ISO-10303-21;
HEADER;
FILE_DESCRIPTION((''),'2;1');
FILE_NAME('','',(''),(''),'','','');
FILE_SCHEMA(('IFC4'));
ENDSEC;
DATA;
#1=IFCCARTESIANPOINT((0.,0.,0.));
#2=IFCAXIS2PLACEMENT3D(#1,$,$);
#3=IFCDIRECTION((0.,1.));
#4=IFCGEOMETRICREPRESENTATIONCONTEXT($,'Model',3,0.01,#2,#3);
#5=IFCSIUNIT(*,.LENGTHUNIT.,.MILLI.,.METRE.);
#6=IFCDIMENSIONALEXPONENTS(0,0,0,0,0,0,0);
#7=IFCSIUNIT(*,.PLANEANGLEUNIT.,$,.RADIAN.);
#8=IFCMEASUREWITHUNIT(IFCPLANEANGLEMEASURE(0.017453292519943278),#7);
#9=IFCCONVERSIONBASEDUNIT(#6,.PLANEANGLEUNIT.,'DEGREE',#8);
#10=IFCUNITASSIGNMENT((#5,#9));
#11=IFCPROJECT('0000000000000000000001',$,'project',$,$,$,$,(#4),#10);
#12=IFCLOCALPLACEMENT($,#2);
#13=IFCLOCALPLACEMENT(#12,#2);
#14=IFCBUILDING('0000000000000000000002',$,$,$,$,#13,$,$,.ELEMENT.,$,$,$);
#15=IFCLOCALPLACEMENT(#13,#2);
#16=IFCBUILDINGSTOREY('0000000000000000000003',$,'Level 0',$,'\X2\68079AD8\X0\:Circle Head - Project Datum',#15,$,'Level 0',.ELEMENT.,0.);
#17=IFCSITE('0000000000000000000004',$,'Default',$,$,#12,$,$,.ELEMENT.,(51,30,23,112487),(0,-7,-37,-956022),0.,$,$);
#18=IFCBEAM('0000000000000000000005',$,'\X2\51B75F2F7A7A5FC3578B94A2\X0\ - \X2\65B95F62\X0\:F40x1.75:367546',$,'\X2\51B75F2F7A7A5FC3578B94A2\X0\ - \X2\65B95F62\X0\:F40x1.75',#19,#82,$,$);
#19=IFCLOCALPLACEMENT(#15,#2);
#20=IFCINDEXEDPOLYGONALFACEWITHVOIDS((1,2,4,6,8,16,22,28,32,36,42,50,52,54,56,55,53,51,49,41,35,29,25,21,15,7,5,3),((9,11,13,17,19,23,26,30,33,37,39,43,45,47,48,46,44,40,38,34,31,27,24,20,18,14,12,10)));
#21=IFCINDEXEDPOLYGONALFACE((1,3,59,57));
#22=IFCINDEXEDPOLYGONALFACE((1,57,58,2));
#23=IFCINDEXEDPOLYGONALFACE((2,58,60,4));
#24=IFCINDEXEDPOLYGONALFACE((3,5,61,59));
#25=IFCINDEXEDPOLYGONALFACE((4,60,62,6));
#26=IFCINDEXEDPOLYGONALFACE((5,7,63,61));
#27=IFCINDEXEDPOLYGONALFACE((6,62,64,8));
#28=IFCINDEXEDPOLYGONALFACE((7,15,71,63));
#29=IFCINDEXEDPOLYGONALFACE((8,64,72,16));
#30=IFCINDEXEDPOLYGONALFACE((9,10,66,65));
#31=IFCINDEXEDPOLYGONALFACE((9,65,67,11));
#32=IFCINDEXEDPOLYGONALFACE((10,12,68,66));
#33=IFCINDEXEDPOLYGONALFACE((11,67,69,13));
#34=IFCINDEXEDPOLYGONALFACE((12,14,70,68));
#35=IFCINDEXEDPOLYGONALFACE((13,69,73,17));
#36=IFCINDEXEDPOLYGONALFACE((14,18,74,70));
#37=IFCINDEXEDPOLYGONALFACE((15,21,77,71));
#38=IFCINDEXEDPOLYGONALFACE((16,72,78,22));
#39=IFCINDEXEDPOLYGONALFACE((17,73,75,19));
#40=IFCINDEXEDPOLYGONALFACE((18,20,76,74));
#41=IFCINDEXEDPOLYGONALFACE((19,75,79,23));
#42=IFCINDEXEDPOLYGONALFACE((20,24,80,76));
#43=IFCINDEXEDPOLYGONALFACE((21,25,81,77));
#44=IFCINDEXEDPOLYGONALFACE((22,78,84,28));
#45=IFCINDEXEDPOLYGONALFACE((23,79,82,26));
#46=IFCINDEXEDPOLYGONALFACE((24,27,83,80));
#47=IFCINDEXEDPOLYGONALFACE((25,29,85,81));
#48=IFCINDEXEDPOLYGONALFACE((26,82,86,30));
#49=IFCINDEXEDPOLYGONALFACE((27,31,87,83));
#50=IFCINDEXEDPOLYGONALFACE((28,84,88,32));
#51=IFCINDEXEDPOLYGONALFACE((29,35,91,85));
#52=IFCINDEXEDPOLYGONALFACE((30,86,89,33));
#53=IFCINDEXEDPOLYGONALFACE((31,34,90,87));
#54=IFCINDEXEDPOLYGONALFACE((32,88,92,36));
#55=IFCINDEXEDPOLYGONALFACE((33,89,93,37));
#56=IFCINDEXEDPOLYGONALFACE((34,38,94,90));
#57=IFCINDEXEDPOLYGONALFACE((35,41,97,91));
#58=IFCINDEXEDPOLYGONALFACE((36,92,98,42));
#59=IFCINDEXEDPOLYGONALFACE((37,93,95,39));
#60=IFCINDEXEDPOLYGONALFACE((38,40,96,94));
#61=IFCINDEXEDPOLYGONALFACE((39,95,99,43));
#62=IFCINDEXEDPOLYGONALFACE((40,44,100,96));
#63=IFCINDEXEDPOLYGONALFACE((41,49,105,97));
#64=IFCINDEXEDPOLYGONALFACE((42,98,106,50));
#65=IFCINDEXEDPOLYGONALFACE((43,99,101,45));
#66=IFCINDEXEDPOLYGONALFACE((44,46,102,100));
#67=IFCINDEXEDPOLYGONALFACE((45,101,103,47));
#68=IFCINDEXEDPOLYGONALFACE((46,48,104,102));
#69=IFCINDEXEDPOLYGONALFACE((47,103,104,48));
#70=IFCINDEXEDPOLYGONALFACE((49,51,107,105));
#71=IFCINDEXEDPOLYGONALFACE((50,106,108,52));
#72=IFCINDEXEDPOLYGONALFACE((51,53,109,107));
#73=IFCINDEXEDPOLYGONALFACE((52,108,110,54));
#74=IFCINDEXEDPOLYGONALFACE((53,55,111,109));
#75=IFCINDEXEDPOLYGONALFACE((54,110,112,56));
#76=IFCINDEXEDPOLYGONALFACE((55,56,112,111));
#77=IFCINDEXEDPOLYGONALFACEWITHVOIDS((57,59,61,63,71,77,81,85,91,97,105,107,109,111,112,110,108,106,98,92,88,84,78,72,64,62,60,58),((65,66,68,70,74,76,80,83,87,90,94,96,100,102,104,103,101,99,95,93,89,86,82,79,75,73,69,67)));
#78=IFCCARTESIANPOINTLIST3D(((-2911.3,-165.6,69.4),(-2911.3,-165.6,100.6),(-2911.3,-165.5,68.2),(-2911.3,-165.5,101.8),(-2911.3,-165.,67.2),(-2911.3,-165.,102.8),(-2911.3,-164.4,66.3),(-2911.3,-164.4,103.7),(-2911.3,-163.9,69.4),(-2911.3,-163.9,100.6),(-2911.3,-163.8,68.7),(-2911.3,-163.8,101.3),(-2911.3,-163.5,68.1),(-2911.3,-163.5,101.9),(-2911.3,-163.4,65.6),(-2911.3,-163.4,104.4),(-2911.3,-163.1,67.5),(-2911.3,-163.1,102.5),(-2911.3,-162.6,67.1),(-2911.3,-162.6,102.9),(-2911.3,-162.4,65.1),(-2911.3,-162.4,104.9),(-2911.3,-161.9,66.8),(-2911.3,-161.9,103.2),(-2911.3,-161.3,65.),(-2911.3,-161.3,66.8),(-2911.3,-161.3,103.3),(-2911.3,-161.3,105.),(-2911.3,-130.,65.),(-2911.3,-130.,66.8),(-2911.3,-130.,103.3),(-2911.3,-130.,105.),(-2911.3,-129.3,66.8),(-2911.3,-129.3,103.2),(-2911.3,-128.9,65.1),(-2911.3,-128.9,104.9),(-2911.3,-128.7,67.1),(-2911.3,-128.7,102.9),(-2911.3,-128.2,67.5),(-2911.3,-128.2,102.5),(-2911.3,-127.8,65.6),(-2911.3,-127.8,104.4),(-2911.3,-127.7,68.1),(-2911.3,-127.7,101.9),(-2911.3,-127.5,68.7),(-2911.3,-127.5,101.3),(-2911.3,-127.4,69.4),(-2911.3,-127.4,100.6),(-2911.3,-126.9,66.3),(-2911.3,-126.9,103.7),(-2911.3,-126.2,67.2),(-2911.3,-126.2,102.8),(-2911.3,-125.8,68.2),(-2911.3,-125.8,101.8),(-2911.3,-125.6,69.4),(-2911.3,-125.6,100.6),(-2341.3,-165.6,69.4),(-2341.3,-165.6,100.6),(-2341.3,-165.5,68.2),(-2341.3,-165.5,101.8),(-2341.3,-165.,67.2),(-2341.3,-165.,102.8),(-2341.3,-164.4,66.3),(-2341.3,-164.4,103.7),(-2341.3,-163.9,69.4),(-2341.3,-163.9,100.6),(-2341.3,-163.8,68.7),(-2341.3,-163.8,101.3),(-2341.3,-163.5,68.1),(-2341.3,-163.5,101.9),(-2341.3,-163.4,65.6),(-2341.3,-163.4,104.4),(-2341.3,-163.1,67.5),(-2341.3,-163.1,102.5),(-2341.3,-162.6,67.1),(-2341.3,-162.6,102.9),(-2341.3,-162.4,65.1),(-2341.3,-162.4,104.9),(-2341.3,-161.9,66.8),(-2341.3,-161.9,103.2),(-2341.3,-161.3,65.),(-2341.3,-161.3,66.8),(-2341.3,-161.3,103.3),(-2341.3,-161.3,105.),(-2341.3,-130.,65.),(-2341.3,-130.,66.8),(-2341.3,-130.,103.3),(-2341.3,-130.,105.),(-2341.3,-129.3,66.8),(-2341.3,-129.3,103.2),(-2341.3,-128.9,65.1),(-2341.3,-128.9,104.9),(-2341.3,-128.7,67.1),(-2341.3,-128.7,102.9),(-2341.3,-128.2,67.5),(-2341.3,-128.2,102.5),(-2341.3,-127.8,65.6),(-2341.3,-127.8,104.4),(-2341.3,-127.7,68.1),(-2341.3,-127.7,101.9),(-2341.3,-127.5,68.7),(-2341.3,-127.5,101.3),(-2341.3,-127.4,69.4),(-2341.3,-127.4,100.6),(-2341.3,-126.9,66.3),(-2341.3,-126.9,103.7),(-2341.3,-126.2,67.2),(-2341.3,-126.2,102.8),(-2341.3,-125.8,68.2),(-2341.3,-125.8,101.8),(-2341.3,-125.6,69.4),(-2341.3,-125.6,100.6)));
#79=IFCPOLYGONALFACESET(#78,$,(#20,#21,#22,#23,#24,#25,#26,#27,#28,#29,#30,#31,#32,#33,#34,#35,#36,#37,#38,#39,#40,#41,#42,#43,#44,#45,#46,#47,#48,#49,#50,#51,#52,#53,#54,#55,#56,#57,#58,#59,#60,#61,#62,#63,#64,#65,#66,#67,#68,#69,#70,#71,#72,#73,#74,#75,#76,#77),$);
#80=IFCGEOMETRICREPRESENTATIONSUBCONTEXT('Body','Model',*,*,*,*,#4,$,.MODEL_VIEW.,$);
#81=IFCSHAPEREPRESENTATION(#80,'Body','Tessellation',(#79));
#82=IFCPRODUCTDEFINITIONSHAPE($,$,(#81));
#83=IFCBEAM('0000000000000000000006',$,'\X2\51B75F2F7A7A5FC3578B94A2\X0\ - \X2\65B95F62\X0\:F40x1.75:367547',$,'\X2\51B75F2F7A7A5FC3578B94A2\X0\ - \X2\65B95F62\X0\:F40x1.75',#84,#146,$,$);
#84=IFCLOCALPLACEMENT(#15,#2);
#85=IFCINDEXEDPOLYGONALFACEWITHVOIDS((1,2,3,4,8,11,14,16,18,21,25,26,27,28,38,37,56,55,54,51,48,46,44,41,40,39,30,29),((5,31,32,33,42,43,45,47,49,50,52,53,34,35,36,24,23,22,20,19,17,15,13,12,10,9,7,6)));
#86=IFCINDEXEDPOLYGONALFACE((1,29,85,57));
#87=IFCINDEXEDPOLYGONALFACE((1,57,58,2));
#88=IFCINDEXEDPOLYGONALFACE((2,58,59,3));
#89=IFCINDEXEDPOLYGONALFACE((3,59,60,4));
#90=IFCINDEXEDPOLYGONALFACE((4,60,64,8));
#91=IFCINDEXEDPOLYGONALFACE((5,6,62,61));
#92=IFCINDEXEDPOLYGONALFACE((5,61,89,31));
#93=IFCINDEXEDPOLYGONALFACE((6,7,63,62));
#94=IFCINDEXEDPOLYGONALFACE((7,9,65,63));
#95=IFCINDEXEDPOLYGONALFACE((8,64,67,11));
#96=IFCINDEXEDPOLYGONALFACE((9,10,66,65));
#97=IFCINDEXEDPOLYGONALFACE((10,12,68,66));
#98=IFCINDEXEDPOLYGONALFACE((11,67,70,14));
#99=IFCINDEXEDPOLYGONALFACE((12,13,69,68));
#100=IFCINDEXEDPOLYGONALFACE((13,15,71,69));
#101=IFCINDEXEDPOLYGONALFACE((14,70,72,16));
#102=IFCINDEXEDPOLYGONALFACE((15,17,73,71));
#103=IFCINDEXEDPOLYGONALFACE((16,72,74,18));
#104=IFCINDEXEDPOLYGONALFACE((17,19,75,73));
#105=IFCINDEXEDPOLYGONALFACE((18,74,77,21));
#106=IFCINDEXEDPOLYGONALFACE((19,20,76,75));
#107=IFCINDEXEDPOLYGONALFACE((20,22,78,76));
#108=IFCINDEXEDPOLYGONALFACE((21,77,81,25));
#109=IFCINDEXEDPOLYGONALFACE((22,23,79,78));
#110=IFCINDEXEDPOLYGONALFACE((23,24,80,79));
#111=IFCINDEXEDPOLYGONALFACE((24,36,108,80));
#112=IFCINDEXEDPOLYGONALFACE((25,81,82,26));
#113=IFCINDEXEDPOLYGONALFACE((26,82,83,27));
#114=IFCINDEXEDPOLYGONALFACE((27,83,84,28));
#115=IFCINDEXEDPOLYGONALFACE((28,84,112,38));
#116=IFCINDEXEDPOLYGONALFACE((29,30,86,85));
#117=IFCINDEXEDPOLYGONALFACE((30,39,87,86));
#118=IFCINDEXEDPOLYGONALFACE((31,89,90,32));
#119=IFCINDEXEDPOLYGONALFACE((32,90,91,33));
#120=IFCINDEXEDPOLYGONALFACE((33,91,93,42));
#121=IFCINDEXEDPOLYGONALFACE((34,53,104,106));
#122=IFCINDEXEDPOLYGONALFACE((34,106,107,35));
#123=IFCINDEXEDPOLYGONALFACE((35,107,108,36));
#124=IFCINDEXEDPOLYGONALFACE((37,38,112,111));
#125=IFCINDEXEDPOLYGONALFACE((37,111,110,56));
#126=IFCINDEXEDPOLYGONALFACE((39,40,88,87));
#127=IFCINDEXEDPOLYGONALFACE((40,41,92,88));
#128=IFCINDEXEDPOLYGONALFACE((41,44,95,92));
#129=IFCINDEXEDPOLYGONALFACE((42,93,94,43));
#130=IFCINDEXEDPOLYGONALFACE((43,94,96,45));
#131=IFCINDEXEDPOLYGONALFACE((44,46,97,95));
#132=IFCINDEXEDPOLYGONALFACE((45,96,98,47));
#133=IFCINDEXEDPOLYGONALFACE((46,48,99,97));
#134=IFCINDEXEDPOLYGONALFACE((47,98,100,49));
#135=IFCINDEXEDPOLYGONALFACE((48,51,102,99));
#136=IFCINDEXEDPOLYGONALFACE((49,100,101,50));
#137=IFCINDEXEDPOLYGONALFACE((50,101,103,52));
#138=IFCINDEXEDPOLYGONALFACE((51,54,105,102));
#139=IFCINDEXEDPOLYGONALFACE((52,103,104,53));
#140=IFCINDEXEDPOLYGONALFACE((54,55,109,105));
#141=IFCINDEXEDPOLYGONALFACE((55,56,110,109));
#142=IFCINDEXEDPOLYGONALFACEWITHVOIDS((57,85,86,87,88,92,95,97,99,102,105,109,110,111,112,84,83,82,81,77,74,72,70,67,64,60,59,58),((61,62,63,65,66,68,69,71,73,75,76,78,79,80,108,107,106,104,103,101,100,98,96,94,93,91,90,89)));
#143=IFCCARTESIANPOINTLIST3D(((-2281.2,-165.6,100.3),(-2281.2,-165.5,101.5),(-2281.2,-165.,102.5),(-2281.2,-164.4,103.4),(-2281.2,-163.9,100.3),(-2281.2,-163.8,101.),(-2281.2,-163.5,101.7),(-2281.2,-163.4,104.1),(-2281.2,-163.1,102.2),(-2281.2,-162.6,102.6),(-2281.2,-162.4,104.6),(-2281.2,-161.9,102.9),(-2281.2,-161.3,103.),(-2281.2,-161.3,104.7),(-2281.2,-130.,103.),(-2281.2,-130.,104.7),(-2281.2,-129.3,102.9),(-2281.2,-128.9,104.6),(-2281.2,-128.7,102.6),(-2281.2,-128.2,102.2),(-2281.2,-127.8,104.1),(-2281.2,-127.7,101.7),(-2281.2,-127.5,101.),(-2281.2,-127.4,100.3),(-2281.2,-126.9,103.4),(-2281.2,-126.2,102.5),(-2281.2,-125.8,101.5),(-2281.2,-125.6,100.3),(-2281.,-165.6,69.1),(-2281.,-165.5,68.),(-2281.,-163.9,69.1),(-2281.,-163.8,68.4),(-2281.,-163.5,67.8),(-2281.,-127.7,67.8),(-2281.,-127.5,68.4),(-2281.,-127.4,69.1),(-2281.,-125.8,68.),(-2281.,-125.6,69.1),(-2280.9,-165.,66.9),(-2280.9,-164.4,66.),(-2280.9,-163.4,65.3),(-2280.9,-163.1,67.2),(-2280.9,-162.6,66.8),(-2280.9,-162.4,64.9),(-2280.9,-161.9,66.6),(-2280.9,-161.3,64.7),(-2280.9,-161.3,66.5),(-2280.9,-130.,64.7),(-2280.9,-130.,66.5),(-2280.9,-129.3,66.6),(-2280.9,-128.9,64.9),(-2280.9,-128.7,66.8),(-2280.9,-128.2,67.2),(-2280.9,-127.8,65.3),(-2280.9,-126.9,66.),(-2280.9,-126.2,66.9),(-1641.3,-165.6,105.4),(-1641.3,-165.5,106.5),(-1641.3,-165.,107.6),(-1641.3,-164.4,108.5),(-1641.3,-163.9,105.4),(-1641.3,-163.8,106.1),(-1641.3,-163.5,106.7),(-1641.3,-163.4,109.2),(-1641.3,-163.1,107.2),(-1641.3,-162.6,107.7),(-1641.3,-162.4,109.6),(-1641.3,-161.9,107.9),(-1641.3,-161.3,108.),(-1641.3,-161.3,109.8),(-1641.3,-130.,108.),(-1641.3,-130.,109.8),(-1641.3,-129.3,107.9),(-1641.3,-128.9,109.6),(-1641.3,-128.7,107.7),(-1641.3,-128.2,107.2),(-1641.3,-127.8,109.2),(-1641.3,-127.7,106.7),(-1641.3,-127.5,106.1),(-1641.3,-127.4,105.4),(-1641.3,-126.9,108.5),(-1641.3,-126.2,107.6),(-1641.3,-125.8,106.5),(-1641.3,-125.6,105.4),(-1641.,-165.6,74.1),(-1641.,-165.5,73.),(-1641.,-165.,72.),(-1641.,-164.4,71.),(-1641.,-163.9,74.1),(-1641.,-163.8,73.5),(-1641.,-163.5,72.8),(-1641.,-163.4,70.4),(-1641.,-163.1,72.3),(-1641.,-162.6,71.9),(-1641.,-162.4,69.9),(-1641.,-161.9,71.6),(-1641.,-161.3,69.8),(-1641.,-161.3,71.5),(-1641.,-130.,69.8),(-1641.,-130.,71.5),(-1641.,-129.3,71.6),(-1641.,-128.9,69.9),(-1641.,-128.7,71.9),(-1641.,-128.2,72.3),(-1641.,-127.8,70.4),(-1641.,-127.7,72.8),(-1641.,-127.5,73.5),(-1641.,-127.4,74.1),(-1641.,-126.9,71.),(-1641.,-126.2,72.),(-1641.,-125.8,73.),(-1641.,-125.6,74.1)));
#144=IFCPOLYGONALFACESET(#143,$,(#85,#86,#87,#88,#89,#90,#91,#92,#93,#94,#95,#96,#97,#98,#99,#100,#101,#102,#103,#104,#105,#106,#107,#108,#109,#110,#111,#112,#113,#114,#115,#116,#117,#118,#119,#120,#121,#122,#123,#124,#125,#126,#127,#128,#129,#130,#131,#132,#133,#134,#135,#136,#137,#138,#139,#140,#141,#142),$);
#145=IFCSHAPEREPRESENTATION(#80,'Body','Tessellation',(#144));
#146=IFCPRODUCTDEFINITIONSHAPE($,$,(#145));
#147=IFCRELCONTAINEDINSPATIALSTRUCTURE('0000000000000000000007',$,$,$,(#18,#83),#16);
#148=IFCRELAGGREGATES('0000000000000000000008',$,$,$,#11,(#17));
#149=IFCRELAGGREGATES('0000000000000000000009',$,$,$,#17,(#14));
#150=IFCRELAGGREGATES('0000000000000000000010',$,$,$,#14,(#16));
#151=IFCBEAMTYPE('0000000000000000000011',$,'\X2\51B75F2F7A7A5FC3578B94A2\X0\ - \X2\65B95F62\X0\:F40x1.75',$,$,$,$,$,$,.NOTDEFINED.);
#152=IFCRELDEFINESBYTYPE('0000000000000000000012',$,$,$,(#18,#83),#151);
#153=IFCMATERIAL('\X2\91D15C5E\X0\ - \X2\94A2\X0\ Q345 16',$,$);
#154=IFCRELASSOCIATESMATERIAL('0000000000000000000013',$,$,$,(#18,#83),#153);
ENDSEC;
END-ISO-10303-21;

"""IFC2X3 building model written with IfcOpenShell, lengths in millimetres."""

from ifc_helpers import new_model, entity, si_unit, converted_unit, direction, frame, frame_2d, origin, place, context, subcontext, project, spatial, polyline, circle_curve, parameter, trimmed, segment, composite_curve, outline, extrude, material, type_object, element, save


model = new_model("IFC2X3")

# Units and contexts
model_context = context("Model", 3, precision=0.01, world=origin(), true_north=direction((0.0, 1.0)))
body_context = subcontext(model_context, "Body", "Model", "MODEL_VIEW")
ifc_project = project(units=[si_unit("LENGTHUNIT", "METRE", prefix="MILLI"), converted_unit("PLANEANGLEUNIT", "DEGREE", entity("IfcPlaneAngleMeasure", 0.017453292519943278), si_unit("PLANEANGLEUNIT", "RADIAN"), dimensions=[0, 0, 0, 0, 0, 0, 0])], contexts=[model_context])

# Site, building, storey
site_placement = place(None, origin())
site = spatial("IfcSite", under=ifc_project, at=site_placement, Name="Default", CompositionType="ELEMENT", RefLatitude=(51, 30, 23, 112487), RefLongitude=(0, -7, -37, -956022), RefElevation=0.0)
building_placement = place(site_placement, origin())
building = spatial("IfcBuilding", under=site, at=building_placement, CompositionType="ELEMENT")
storey_placement = place(building_placement, origin())
storey = spatial("IfcBuildingStorey", under=building, at=storey_placement, Name="Level 0", ObjectType="标高:Circle Head - Project Datum", LongName="Level 0", CompositionType="ELEMENT", Elevation=0.0)

# Beams
ifc_material_1 = material(Name="金属 - 钢 Q345 16")
beam_type_1 = type_object("IfcBeamType", Name="冷弯空心型钢 - 方形:F40x1.75", PredefinedType="NOTDEFINED")
beam_1_placement = place(storey_placement, frame((-2946.3, -145.6, 105.0)))
element("IfcBeam", 1, at=beam_1_placement, inside=storey, type_object=beam_type_1, material=ifc_material_1, Name="冷弯空心型钢 - 方形:F40x1.75:367546", ObjectType="冷弯空心型钢 - 方形:F40x1.75", context=body_context, shape_type="SweptSolid", body=[
    extrude(outline(composite_curve([segment(trimmed(circle_curve(frame_2d((-15.6, 15.6), x_axis=(1.0, 0.0)), 4.4), [parameter(90.0)], [parameter(180.0)], True, "PARAMETER"), True, "CONTINUOUS"), segment(polyline([(-20.0, 15.6), (-20.0, -15.6)]), True, "CONTINUOUS"), segment(trimmed(circle_curve(frame_2d((-15.6, -15.6), x_axis=(1.0, 0.0)), 4.4), [parameter(180.0)], [parameter(270.0)], True, "PARAMETER"), True, "CONTINUOUS"), segment(polyline([(-15.6, -20.0), (15.6, -20.0)]), True, "CONTINUOUS"), segment(trimmed(circle_curve(frame_2d((15.6, -15.6), x_axis=(1.0, 0.0)), 4.4), [parameter(270.0)], [parameter(0.0)], True, "PARAMETER"), True, "CONTINUOUS"), segment(polyline([(20.0, -15.6), (20.0, 15.6)]), True, "CONTINUOUS"), segment(trimmed(circle_curve(frame_2d((15.6, 15.6), x_axis=(1.0, 0.0)), 4.4), [parameter(0.0)], [parameter(90.0)], True, "PARAMETER"), True, "CONTINUOUS"), segment(polyline([(15.6, 20.0), (-15.6, 20.0)]), True, "CONTINUOUS")], self_intersect=False), holes=[composite_curve([segment(polyline([(-15.6, 18.3), (15.6, 18.3)]), True, "CONTINUOUS"), segment(trimmed(circle_curve(frame_2d((15.6, 15.6), x_axis=(1.0, 0.0)), 2.6), [parameter(0.0)], [parameter(90.0)], True, "PARAMETER"), False, "CONTINUOUS"), segment(polyline([(18.2, 15.6), (18.2, -15.6)]), True, "CONTINUOUS"), segment(trimmed(circle_curve(frame_2d((15.6, -15.6), x_axis=(1.0, 0.0)), 2.6), [parameter(270.0)], [parameter(360.0)], True, "PARAMETER"), False, "CONTINUOUS"), segment(polyline([(15.6, -18.2), (-15.6, -18.2)]), True, "CONTINUOUS"), segment(trimmed(circle_curve(frame_2d((-15.6, -15.6), x_axis=(1.0, 0.0)), 2.6), [parameter(180.0)], [parameter(270.0)], True, "PARAMETER"), False, "CONTINUOUS"), segment(polyline([(-18.3, -15.6), (-18.3, 15.6)]), True, "CONTINUOUS"), segment(trimmed(circle_curve(frame_2d((-15.6, 15.6), x_axis=(1.0, 0.0)), 2.6), [parameter(90.0)], [parameter(180.0)], True, "PARAMETER"), False, "CONTINUOUS")], self_intersect=False)]), frame((35.0, 0.0, -20.0), z_axis=(1.0, 0.0, 0.0), x_axis=(0.0, 1.0, 0.0)), (0.0, 0.0, 1.0), 570.0),
])
beam_2_placement = place(storey_placement, frame((-2246.3, -145.6, 105.0), z_axis=(-0.007874, 0.0, 0.999969), x_axis=(0.999969, 0.0, 0.007874)))
element("IfcBeam", 2, at=beam_2_placement, inside=storey, type_object=beam_type_1, material=ifc_material_1, Name="冷弯空心型钢 - 方形:F40x1.75:367547", ObjectType="冷弯空心型钢 - 方形:F40x1.75", context=body_context, shape_type="SweptSolid", body=[
    extrude(outline(composite_curve([segment(trimmed(circle_curve(frame_2d((-15.6, 15.6), x_axis=(1.0, 0.0)), 4.4), [parameter(90.0)], [parameter(180.0)], True, "PARAMETER"), True, "CONTINUOUS"), segment(polyline([(-20.0, 15.6), (-20.0, -15.6)]), True, "CONTINUOUS"), segment(trimmed(circle_curve(frame_2d((-15.6, -15.6), x_axis=(1.0, 0.0)), 4.4), [parameter(180.0)], [parameter(270.0)], True, "PARAMETER"), True, "CONTINUOUS"), segment(polyline([(-15.6, -20.0), (15.6, -20.0)]), True, "CONTINUOUS"), segment(trimmed(circle_curve(frame_2d((15.6, -15.6), x_axis=(1.0, 0.0)), 4.4), [parameter(270.0)], [parameter(0.0)], True, "PARAMETER"), True, "CONTINUOUS"), segment(polyline([(20.0, -15.6), (20.0, 15.6)]), True, "CONTINUOUS"), segment(trimmed(circle_curve(frame_2d((15.6, 15.6), x_axis=(1.0, 0.0)), 4.4), [parameter(0.0)], [parameter(90.0)], True, "PARAMETER"), True, "CONTINUOUS"), segment(polyline([(15.6, 20.0), (-15.6, 20.0)]), True, "CONTINUOUS")], self_intersect=False), holes=[composite_curve([segment(polyline([(-15.6, 18.3), (15.6, 18.3)]), True, "CONTINUOUS"), segment(trimmed(circle_curve(frame_2d((15.6, 15.6), x_axis=(1.0, 0.0)), 2.6), [parameter(0.0)], [parameter(90.0)], True, "PARAMETER"), False, "CONTINUOUS"), segment(polyline([(18.2, 15.6), (18.2, -15.6)]), True, "CONTINUOUS"), segment(trimmed(circle_curve(frame_2d((15.6, -15.6), x_axis=(1.0, 0.0)), 2.6), [parameter(270.0)], [parameter(360.0)], True, "PARAMETER"), False, "CONTINUOUS"), segment(polyline([(15.6, -18.2), (-15.6, -18.2)]), True, "CONTINUOUS"), segment(trimmed(circle_curve(frame_2d((-15.6, -15.6), x_axis=(1.0, 0.0)), 2.6), [parameter(180.0)], [parameter(270.0)], True, "PARAMETER"), False, "CONTINUOUS"), segment(polyline([(-18.3, -15.6), (-18.3, 15.6)]), True, "CONTINUOUS"), segment(trimmed(circle_curve(frame_2d((-15.6, 15.6), x_axis=(1.0, 0.0)), 2.6), [parameter(90.0)], [parameter(180.0)], True, "PARAMETER"), False, "CONTINUOUS")], self_intersect=False)]), frame((-34.9, 0.0, -20.0), z_axis=(1.0, 0.0, 0.0), x_axis=(0.0, 1.0, 0.0)), (0.0, 0.0, 1.0), 640.0),
])

save(model, "model.ifc")
